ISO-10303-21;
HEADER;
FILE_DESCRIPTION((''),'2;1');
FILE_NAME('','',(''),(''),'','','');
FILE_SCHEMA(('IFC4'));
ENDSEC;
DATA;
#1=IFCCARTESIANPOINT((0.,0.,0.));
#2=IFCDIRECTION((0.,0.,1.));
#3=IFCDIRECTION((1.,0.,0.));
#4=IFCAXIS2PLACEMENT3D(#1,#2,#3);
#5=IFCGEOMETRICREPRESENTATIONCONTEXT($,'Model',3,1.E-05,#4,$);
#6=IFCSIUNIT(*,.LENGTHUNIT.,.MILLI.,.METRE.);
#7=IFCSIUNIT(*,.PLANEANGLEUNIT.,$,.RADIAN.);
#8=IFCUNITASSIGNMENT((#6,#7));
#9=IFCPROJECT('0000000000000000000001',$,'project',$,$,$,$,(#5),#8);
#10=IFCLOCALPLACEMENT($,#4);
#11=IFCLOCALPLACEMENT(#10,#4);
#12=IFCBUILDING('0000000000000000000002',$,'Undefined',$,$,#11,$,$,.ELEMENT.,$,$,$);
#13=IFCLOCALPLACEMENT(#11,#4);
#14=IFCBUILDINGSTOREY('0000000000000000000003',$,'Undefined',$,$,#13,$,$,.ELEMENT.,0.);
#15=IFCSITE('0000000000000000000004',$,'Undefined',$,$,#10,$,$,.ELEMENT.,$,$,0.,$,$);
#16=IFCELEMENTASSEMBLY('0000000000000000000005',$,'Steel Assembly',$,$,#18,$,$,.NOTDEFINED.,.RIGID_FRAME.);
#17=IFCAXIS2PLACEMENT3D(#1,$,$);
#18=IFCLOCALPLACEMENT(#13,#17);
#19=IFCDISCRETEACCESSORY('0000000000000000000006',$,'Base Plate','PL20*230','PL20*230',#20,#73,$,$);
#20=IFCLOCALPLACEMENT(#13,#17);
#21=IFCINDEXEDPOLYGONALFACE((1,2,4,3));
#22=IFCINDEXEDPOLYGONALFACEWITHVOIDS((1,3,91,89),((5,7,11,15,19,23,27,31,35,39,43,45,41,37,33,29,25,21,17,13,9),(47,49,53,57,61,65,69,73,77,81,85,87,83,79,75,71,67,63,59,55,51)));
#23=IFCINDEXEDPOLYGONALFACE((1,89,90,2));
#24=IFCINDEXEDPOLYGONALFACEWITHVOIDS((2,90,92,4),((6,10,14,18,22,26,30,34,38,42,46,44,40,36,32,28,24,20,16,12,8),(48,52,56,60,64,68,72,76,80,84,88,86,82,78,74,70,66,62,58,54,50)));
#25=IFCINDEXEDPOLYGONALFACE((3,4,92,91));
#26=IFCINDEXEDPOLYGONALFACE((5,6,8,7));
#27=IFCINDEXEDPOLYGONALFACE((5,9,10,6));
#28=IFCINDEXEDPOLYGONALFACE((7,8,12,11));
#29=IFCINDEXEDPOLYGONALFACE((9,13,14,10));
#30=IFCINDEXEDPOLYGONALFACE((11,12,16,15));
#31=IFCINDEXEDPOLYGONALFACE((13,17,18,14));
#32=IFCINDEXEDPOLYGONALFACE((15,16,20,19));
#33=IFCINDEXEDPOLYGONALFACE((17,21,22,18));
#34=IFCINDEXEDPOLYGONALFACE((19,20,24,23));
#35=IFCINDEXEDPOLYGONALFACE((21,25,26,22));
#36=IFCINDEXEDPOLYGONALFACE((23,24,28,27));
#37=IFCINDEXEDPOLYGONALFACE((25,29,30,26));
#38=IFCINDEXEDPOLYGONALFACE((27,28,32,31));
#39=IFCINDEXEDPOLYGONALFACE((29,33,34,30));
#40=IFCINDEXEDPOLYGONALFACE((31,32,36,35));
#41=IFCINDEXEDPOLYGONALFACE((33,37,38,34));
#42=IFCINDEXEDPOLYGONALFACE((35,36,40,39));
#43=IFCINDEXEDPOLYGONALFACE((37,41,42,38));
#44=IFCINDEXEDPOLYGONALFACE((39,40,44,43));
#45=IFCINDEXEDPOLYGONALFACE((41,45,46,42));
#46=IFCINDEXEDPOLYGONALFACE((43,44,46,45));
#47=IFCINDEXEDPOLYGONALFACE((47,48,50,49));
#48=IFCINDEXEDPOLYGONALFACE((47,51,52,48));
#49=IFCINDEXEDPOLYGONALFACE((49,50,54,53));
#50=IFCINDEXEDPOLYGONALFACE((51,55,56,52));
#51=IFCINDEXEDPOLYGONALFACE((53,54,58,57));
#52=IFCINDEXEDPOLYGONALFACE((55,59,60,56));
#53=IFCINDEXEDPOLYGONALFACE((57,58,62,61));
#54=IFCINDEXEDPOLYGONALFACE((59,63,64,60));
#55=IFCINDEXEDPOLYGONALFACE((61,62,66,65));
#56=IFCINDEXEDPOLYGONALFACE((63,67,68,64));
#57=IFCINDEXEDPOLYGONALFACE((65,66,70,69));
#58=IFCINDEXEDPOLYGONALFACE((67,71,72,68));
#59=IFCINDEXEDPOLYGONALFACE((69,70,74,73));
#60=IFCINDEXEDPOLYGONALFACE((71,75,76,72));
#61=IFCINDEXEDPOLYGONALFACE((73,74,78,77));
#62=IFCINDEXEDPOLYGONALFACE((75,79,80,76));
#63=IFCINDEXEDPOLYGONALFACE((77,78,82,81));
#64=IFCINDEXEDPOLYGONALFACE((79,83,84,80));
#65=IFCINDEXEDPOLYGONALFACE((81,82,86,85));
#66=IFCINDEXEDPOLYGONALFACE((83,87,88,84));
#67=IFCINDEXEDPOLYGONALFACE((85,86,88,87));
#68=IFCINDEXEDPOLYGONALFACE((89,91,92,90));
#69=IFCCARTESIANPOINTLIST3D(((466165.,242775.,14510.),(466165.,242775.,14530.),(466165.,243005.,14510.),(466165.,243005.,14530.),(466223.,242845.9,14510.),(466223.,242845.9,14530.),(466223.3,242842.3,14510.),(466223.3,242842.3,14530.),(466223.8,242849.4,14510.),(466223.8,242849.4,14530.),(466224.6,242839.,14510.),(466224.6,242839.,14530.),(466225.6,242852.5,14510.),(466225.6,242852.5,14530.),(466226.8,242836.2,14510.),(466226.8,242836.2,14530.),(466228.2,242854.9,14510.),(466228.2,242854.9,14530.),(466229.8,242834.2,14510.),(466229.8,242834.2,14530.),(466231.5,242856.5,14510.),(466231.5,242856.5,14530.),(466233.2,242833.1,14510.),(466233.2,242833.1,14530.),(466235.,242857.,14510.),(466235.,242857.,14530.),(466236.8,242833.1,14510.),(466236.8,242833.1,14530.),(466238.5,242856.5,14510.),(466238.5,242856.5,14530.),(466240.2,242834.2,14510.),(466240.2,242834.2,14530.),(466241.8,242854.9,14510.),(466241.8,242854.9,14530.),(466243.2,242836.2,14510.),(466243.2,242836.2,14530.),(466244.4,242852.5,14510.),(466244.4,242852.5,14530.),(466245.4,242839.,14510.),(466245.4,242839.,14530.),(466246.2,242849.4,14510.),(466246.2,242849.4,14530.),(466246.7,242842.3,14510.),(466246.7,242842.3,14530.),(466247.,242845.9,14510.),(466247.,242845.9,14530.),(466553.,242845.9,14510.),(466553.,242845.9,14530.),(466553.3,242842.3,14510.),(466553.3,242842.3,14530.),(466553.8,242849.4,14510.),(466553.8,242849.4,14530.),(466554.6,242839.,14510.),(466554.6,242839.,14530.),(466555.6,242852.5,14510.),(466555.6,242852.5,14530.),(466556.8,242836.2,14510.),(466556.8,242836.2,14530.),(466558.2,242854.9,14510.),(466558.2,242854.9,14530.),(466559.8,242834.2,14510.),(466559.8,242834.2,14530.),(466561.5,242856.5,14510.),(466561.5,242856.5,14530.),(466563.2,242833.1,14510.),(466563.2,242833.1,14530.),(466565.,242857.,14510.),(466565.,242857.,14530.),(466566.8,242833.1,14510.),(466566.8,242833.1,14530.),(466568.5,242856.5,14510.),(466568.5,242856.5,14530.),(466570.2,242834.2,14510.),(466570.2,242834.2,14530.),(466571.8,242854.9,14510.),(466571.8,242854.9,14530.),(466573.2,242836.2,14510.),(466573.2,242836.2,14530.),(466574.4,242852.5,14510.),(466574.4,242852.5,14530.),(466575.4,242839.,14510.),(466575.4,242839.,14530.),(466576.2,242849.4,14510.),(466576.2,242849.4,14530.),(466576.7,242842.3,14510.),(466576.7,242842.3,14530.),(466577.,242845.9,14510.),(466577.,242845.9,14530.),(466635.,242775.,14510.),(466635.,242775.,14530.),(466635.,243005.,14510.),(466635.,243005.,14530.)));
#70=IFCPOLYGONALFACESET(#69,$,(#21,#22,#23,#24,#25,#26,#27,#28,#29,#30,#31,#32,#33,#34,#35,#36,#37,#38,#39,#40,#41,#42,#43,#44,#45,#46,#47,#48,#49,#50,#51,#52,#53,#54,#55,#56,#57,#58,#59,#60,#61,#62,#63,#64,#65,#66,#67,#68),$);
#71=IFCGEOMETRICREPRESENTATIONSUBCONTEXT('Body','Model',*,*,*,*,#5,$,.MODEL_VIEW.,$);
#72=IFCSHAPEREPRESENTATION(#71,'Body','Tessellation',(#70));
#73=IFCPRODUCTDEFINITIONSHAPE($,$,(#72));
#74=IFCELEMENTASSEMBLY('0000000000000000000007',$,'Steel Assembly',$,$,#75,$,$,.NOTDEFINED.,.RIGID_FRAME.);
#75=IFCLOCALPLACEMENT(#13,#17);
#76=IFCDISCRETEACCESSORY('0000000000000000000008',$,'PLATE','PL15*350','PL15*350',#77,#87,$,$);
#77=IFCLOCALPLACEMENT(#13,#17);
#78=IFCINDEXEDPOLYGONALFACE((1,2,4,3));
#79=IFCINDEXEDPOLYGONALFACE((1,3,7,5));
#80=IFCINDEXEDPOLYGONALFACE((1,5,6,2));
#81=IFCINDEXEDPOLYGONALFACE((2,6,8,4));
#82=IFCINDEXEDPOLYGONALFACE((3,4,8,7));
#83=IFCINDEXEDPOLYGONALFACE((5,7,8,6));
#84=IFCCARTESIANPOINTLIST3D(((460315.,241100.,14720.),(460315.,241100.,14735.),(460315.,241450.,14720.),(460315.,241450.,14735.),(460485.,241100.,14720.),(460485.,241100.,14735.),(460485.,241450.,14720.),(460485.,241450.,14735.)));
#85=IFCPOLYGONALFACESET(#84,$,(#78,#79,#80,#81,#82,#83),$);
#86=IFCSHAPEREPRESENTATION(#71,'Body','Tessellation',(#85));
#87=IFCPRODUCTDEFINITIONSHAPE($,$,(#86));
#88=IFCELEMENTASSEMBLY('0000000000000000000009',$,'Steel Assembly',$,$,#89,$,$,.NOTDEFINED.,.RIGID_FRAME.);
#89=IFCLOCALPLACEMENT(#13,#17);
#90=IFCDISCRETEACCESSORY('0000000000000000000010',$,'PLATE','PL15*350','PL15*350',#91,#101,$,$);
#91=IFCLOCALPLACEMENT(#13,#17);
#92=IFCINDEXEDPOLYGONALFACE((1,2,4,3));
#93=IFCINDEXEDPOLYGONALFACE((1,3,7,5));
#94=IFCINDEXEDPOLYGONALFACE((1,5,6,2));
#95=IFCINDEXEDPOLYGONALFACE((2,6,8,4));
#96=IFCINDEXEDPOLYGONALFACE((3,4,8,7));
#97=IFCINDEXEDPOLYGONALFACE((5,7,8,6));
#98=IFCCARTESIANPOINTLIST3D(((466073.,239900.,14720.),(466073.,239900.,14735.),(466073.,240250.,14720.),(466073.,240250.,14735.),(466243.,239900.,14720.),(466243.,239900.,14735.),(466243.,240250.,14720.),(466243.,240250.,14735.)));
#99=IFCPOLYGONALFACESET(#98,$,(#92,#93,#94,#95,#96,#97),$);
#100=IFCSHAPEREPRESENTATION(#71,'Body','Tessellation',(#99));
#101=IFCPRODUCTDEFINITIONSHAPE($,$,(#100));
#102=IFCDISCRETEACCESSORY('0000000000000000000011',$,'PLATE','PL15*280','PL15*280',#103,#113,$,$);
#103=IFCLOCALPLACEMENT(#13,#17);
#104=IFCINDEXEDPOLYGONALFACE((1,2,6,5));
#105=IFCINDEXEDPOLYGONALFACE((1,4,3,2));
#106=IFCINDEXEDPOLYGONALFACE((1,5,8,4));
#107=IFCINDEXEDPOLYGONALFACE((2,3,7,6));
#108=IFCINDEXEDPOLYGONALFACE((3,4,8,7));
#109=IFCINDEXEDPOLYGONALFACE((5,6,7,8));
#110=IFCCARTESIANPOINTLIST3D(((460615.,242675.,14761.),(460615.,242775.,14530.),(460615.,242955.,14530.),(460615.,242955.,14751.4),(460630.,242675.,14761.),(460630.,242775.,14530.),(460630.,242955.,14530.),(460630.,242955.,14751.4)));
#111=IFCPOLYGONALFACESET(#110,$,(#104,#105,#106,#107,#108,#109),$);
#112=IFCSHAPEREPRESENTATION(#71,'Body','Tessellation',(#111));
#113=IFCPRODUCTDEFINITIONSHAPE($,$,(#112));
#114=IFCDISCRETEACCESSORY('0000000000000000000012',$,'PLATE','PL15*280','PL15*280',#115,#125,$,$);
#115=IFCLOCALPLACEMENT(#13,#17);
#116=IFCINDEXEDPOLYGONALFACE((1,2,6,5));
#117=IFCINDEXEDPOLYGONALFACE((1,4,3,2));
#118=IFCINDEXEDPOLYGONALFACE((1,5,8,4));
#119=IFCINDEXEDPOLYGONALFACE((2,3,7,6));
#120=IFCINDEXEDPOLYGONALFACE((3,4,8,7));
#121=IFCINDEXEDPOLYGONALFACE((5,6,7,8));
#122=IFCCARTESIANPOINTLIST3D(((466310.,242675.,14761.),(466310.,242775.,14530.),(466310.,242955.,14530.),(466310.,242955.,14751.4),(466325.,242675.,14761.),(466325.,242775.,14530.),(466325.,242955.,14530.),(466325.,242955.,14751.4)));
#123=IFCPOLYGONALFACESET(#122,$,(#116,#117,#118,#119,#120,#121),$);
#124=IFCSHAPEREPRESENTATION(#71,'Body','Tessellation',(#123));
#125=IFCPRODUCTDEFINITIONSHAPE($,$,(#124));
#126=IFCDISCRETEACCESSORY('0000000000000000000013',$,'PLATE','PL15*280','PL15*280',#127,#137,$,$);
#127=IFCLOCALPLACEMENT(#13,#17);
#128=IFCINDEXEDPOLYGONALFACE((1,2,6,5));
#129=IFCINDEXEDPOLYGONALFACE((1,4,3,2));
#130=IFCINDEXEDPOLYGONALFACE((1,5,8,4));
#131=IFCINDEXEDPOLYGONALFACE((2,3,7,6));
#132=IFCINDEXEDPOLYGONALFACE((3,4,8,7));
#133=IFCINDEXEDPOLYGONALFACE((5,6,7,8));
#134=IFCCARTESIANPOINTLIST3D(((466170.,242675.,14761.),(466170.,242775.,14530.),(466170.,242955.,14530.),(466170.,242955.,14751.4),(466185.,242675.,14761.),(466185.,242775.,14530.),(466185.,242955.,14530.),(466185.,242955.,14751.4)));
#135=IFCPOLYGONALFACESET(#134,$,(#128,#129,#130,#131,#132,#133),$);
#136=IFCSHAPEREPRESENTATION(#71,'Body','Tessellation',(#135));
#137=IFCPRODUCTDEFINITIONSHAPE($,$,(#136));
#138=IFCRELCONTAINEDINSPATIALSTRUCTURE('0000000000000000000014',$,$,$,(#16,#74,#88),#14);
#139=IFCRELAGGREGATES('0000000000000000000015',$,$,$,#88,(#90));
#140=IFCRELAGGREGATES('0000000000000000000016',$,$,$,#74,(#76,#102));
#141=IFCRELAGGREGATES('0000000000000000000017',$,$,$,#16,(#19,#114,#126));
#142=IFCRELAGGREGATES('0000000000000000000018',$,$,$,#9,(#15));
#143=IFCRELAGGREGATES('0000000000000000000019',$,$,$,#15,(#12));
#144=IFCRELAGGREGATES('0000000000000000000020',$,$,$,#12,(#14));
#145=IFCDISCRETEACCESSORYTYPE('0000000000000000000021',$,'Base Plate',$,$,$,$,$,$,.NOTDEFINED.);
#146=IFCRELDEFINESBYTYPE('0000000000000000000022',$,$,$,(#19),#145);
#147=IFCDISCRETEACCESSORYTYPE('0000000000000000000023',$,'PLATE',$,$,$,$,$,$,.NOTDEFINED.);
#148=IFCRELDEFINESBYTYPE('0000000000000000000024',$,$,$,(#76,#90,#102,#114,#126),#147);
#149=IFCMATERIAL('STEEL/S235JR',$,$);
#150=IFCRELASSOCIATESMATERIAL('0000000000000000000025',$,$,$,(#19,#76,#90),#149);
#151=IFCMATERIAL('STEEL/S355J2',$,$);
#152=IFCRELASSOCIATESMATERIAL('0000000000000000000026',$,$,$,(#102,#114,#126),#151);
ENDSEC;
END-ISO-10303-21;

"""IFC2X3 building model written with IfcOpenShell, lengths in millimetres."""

from ifc_helpers import new_model, si_unit, frame, origin_with_axes, origin_2d_with_axis, place, context, subcontext, project, spatial, polyline, circle, outline, extrude, boolean, material, type_object, element, aggregate, save


model = new_model("IFC2X3")

# Units and contexts
model_context = context("Model", 3, precision=1e-05, world=origin_with_axes())
body_context = subcontext(model_context, "Body", "Model", "MODEL_VIEW")
ifc_project = project(units=[si_unit("LENGTHUNIT", "METRE", prefix="MILLI"), si_unit("PLANEANGLEUNIT", "RADIAN")], contexts=[model_context])

# Site, building, storey
site_placement = place(None, origin_with_axes())
site = spatial("IfcSite", under=ifc_project, at=site_placement, Name="Undefined", CompositionType="ELEMENT", RefElevation=0.0)
building_placement = place(site_placement, origin_with_axes())
building = spatial("IfcBuilding", under=site, at=building_placement, Name="Undefined", CompositionType="ELEMENT")
storey_placement = place(building_placement, origin_with_axes())
storey = spatial("IfcBuildingStorey", under=building, at=storey_placement, Name="Undefined", CompositionType="ELEMENT", Elevation=0.0)

# Shared definitions
ifc_material_1 = material(Name="STEEL/S235JR")

# Shared definitions
ifc_material_2 = material(Name="STEEL/S355J2")

# Element assembly, discrete accessory
assembly_1_placement = place(storey_placement, origin_with_axes())
assembly_1 = element("IfcElementAssembly", 1, at=assembly_1_placement, inside=storey, Name="Steel Assembly", AssemblyPlace="NOTDEFINED", PredefinedType="RIGID_FRAME")
discrete_accessory_type_1 = type_object("IfcDiscreteAccessoryType", Name="Base Plate")
discrete_accessory_1_placement = place(assembly_1_placement, frame((466165.0, 243005.0, 14520.0), z_axis=(0.0, 0.0, -1.0), x_axis=(1.0, 0.0, 0.0)))
discrete_accessory_1 = element("IfcDiscreteAccessory", 2, at=discrete_accessory_1_placement, type_object=discrete_accessory_type_1, material=ifc_material_1, Name="Base Plate", Description="PL20*230", ObjectType="PL20*230", context=body_context, shape_type="CSG", body=[
    boolean("DIFFERENCE", boolean("DIFFERENCE", extrude(outline(polyline([(0.0, 0.0), (470.0, 0.0), (470.0, 230.0), (0.0, 230.0), (0.0, 0.0)])), frame((0.0, 0.0, -10.0), z_axis=(0.0, 0.0, 1.0), x_axis=(1.0, 0.0, 0.0)), (0.0, 0.0, 1.0), 20.0), extrude(circle(Radius=12.0, at=origin_2d_with_axis()), frame((70.0, 160.0, -80.0), z_axis=(0.0, 0.0, 1.0), x_axis=(0.0, -1.0, 0.0)), (0.0, 0.0, 1.0), 170.0)), extrude(circle(Radius=12.0, at=origin_2d_with_axis()), frame((400.0, 160.0, -80.0), z_axis=(0.0, 0.0, 1.0), x_axis=(0.0, -1.0, 0.0)), (0.0, 0.0, 1.0), 170.0)),
])

# Element assemblies, discrete accessories
assembly_2_placement = place(storey_placement, origin_with_axes())
assembly_2 = element("IfcElementAssembly", 3, at=assembly_2_placement, inside=storey, Name="Steel Assembly", AssemblyPlace="NOTDEFINED", PredefinedType="RIGID_FRAME")
discrete_accessory_type_2 = type_object("IfcDiscreteAccessoryType", Name="PLATE")
discrete_accessory_2_placement = place(assembly_2_placement, frame((460485.0, 241275.0, 14727.5), z_axis=(0.0, 0.0, 1.0), x_axis=(-1.0, 0.0, 0.0)))
discrete_accessory_2 = element("IfcDiscreteAccessory", 4, at=discrete_accessory_2_placement, type_object=discrete_accessory_type_2, material=ifc_material_1, Name="PLATE", Description="PL15*350", ObjectType="PL15*350", context=body_context, shape_type="SweptSolid", body=[
    extrude(outline(polyline([(170.0, -175.0), (0.0, -175.0), (0.0, 175.0), (170.0, 175.0), (170.0, -175.0)])), frame((0.0, 0.0, -7.5), z_axis=(0.0, 0.0, 1.0), x_axis=(1.0, 0.0, 0.0)), (0.0, 0.0, 1.0), 15.0),
])
assembly_3_placement = place(storey_placement, origin_with_axes())
assembly_3 = element("IfcElementAssembly", 5, at=assembly_3_placement, inside=storey, Name="Steel Assembly", AssemblyPlace="NOTDEFINED", PredefinedType="RIGID_FRAME")
discrete_accessory_3_placement = place(assembly_3_placement, frame((466243.0, 240075.0, 14727.5), z_axis=(0.0, 0.0, 1.0), x_axis=(-1.0, 0.0, 0.0)))
discrete_accessory_3 = element("IfcDiscreteAccessory", 6, at=discrete_accessory_3_placement, type_object=discrete_accessory_type_2, material=ifc_material_1, Name="PLATE", Description="PL15*350", ObjectType="PL15*350", context=body_context, shape_type="SweptSolid", body=[
    extrude(outline(polyline([(170.0, -175.0), (0.0, -175.0), (0.0, 175.0), (170.0, 175.0), (170.0, -175.0)])), frame((0.0, 0.0, -7.5), z_axis=(0.0, 0.0, 1.0), x_axis=(1.0, 0.0, 0.0)), (0.0, 0.0, 1.0), 15.0),
])
aggregate(assembly_3, [discrete_accessory_3])

# Discrete accessories
discrete_accessory_4_placement = place(assembly_2_placement, frame((460622.5, 242955.0, 14530.0), z_axis=(-1.0, 0.0, 0.0), x_axis=(0.0, -1.0, 0.0)))
discrete_accessory_4 = element("IfcDiscreteAccessory", 7, at=discrete_accessory_4_placement, type_object=discrete_accessory_type_2, material=ifc_material_2, Name="PLATE", Description="PL15*280", ObjectType="PL15*280", context=body_context, shape_type="SweptSolid", body=[
    extrude(outline(polyline([(0.0, 0.0), (180.0, 0.0), (280.0, 231.0), (0.0, 221.4), (0.0, 0.0)])), frame((0.0, 0.0, -7.5), z_axis=(0.0, 0.0, 1.0), x_axis=(1.0, 0.0, 0.0)), (0.0, 0.0, 1.0), 15.0),
])
aggregate(assembly_2, [discrete_accessory_2, discrete_accessory_4])
discrete_accessory_5_placement = place(assembly_1_placement, frame((466317.5, 242955.0, 14530.0), z_axis=(-1.0, 0.0, 0.0), x_axis=(0.0, -1.0, 0.0)))
discrete_accessory_5 = element("IfcDiscreteAccessory", 8, at=discrete_accessory_5_placement, type_object=discrete_accessory_type_2, material=ifc_material_2, Name="PLATE", Description="PL15*280", ObjectType="PL15*280", context=body_context, shape_type="SweptSolid", body=[
    extrude(outline(polyline([(0.0, 0.0), (180.0, 0.0), (280.0, 231.0), (0.0, 221.4), (0.0, 0.0)])), frame((0.0, 0.0, -7.5), z_axis=(0.0, 0.0, 1.0), x_axis=(1.0, 0.0, 0.0)), (0.0, 0.0, 1.0), 15.0),
])
discrete_accessory_6_placement = place(assembly_1_placement, frame((466177.5, 242955.0, 14530.0), z_axis=(-1.0, 0.0, 0.0), x_axis=(0.0, -1.0, 0.0)))
discrete_accessory_6 = element("IfcDiscreteAccessory", 9, at=discrete_accessory_6_placement, type_object=discrete_accessory_type_2, material=ifc_material_2, Name="PLATE", Description="PL15*280", ObjectType="PL15*280", context=body_context, shape_type="SweptSolid", body=[
    extrude(outline(polyline([(0.0, 0.0), (180.0, 0.0), (280.0, 231.0), (0.0, 221.4), (0.0, 0.0)])), frame((0.0, 0.0, -7.5), z_axis=(0.0, 0.0, 1.0), x_axis=(1.0, 0.0, 0.0)), (0.0, 0.0, 1.0), 15.0),
])
aggregate(assembly_1, [discrete_accessory_1, discrete_accessory_5, discrete_accessory_6])

save(model, "model.ifc")
